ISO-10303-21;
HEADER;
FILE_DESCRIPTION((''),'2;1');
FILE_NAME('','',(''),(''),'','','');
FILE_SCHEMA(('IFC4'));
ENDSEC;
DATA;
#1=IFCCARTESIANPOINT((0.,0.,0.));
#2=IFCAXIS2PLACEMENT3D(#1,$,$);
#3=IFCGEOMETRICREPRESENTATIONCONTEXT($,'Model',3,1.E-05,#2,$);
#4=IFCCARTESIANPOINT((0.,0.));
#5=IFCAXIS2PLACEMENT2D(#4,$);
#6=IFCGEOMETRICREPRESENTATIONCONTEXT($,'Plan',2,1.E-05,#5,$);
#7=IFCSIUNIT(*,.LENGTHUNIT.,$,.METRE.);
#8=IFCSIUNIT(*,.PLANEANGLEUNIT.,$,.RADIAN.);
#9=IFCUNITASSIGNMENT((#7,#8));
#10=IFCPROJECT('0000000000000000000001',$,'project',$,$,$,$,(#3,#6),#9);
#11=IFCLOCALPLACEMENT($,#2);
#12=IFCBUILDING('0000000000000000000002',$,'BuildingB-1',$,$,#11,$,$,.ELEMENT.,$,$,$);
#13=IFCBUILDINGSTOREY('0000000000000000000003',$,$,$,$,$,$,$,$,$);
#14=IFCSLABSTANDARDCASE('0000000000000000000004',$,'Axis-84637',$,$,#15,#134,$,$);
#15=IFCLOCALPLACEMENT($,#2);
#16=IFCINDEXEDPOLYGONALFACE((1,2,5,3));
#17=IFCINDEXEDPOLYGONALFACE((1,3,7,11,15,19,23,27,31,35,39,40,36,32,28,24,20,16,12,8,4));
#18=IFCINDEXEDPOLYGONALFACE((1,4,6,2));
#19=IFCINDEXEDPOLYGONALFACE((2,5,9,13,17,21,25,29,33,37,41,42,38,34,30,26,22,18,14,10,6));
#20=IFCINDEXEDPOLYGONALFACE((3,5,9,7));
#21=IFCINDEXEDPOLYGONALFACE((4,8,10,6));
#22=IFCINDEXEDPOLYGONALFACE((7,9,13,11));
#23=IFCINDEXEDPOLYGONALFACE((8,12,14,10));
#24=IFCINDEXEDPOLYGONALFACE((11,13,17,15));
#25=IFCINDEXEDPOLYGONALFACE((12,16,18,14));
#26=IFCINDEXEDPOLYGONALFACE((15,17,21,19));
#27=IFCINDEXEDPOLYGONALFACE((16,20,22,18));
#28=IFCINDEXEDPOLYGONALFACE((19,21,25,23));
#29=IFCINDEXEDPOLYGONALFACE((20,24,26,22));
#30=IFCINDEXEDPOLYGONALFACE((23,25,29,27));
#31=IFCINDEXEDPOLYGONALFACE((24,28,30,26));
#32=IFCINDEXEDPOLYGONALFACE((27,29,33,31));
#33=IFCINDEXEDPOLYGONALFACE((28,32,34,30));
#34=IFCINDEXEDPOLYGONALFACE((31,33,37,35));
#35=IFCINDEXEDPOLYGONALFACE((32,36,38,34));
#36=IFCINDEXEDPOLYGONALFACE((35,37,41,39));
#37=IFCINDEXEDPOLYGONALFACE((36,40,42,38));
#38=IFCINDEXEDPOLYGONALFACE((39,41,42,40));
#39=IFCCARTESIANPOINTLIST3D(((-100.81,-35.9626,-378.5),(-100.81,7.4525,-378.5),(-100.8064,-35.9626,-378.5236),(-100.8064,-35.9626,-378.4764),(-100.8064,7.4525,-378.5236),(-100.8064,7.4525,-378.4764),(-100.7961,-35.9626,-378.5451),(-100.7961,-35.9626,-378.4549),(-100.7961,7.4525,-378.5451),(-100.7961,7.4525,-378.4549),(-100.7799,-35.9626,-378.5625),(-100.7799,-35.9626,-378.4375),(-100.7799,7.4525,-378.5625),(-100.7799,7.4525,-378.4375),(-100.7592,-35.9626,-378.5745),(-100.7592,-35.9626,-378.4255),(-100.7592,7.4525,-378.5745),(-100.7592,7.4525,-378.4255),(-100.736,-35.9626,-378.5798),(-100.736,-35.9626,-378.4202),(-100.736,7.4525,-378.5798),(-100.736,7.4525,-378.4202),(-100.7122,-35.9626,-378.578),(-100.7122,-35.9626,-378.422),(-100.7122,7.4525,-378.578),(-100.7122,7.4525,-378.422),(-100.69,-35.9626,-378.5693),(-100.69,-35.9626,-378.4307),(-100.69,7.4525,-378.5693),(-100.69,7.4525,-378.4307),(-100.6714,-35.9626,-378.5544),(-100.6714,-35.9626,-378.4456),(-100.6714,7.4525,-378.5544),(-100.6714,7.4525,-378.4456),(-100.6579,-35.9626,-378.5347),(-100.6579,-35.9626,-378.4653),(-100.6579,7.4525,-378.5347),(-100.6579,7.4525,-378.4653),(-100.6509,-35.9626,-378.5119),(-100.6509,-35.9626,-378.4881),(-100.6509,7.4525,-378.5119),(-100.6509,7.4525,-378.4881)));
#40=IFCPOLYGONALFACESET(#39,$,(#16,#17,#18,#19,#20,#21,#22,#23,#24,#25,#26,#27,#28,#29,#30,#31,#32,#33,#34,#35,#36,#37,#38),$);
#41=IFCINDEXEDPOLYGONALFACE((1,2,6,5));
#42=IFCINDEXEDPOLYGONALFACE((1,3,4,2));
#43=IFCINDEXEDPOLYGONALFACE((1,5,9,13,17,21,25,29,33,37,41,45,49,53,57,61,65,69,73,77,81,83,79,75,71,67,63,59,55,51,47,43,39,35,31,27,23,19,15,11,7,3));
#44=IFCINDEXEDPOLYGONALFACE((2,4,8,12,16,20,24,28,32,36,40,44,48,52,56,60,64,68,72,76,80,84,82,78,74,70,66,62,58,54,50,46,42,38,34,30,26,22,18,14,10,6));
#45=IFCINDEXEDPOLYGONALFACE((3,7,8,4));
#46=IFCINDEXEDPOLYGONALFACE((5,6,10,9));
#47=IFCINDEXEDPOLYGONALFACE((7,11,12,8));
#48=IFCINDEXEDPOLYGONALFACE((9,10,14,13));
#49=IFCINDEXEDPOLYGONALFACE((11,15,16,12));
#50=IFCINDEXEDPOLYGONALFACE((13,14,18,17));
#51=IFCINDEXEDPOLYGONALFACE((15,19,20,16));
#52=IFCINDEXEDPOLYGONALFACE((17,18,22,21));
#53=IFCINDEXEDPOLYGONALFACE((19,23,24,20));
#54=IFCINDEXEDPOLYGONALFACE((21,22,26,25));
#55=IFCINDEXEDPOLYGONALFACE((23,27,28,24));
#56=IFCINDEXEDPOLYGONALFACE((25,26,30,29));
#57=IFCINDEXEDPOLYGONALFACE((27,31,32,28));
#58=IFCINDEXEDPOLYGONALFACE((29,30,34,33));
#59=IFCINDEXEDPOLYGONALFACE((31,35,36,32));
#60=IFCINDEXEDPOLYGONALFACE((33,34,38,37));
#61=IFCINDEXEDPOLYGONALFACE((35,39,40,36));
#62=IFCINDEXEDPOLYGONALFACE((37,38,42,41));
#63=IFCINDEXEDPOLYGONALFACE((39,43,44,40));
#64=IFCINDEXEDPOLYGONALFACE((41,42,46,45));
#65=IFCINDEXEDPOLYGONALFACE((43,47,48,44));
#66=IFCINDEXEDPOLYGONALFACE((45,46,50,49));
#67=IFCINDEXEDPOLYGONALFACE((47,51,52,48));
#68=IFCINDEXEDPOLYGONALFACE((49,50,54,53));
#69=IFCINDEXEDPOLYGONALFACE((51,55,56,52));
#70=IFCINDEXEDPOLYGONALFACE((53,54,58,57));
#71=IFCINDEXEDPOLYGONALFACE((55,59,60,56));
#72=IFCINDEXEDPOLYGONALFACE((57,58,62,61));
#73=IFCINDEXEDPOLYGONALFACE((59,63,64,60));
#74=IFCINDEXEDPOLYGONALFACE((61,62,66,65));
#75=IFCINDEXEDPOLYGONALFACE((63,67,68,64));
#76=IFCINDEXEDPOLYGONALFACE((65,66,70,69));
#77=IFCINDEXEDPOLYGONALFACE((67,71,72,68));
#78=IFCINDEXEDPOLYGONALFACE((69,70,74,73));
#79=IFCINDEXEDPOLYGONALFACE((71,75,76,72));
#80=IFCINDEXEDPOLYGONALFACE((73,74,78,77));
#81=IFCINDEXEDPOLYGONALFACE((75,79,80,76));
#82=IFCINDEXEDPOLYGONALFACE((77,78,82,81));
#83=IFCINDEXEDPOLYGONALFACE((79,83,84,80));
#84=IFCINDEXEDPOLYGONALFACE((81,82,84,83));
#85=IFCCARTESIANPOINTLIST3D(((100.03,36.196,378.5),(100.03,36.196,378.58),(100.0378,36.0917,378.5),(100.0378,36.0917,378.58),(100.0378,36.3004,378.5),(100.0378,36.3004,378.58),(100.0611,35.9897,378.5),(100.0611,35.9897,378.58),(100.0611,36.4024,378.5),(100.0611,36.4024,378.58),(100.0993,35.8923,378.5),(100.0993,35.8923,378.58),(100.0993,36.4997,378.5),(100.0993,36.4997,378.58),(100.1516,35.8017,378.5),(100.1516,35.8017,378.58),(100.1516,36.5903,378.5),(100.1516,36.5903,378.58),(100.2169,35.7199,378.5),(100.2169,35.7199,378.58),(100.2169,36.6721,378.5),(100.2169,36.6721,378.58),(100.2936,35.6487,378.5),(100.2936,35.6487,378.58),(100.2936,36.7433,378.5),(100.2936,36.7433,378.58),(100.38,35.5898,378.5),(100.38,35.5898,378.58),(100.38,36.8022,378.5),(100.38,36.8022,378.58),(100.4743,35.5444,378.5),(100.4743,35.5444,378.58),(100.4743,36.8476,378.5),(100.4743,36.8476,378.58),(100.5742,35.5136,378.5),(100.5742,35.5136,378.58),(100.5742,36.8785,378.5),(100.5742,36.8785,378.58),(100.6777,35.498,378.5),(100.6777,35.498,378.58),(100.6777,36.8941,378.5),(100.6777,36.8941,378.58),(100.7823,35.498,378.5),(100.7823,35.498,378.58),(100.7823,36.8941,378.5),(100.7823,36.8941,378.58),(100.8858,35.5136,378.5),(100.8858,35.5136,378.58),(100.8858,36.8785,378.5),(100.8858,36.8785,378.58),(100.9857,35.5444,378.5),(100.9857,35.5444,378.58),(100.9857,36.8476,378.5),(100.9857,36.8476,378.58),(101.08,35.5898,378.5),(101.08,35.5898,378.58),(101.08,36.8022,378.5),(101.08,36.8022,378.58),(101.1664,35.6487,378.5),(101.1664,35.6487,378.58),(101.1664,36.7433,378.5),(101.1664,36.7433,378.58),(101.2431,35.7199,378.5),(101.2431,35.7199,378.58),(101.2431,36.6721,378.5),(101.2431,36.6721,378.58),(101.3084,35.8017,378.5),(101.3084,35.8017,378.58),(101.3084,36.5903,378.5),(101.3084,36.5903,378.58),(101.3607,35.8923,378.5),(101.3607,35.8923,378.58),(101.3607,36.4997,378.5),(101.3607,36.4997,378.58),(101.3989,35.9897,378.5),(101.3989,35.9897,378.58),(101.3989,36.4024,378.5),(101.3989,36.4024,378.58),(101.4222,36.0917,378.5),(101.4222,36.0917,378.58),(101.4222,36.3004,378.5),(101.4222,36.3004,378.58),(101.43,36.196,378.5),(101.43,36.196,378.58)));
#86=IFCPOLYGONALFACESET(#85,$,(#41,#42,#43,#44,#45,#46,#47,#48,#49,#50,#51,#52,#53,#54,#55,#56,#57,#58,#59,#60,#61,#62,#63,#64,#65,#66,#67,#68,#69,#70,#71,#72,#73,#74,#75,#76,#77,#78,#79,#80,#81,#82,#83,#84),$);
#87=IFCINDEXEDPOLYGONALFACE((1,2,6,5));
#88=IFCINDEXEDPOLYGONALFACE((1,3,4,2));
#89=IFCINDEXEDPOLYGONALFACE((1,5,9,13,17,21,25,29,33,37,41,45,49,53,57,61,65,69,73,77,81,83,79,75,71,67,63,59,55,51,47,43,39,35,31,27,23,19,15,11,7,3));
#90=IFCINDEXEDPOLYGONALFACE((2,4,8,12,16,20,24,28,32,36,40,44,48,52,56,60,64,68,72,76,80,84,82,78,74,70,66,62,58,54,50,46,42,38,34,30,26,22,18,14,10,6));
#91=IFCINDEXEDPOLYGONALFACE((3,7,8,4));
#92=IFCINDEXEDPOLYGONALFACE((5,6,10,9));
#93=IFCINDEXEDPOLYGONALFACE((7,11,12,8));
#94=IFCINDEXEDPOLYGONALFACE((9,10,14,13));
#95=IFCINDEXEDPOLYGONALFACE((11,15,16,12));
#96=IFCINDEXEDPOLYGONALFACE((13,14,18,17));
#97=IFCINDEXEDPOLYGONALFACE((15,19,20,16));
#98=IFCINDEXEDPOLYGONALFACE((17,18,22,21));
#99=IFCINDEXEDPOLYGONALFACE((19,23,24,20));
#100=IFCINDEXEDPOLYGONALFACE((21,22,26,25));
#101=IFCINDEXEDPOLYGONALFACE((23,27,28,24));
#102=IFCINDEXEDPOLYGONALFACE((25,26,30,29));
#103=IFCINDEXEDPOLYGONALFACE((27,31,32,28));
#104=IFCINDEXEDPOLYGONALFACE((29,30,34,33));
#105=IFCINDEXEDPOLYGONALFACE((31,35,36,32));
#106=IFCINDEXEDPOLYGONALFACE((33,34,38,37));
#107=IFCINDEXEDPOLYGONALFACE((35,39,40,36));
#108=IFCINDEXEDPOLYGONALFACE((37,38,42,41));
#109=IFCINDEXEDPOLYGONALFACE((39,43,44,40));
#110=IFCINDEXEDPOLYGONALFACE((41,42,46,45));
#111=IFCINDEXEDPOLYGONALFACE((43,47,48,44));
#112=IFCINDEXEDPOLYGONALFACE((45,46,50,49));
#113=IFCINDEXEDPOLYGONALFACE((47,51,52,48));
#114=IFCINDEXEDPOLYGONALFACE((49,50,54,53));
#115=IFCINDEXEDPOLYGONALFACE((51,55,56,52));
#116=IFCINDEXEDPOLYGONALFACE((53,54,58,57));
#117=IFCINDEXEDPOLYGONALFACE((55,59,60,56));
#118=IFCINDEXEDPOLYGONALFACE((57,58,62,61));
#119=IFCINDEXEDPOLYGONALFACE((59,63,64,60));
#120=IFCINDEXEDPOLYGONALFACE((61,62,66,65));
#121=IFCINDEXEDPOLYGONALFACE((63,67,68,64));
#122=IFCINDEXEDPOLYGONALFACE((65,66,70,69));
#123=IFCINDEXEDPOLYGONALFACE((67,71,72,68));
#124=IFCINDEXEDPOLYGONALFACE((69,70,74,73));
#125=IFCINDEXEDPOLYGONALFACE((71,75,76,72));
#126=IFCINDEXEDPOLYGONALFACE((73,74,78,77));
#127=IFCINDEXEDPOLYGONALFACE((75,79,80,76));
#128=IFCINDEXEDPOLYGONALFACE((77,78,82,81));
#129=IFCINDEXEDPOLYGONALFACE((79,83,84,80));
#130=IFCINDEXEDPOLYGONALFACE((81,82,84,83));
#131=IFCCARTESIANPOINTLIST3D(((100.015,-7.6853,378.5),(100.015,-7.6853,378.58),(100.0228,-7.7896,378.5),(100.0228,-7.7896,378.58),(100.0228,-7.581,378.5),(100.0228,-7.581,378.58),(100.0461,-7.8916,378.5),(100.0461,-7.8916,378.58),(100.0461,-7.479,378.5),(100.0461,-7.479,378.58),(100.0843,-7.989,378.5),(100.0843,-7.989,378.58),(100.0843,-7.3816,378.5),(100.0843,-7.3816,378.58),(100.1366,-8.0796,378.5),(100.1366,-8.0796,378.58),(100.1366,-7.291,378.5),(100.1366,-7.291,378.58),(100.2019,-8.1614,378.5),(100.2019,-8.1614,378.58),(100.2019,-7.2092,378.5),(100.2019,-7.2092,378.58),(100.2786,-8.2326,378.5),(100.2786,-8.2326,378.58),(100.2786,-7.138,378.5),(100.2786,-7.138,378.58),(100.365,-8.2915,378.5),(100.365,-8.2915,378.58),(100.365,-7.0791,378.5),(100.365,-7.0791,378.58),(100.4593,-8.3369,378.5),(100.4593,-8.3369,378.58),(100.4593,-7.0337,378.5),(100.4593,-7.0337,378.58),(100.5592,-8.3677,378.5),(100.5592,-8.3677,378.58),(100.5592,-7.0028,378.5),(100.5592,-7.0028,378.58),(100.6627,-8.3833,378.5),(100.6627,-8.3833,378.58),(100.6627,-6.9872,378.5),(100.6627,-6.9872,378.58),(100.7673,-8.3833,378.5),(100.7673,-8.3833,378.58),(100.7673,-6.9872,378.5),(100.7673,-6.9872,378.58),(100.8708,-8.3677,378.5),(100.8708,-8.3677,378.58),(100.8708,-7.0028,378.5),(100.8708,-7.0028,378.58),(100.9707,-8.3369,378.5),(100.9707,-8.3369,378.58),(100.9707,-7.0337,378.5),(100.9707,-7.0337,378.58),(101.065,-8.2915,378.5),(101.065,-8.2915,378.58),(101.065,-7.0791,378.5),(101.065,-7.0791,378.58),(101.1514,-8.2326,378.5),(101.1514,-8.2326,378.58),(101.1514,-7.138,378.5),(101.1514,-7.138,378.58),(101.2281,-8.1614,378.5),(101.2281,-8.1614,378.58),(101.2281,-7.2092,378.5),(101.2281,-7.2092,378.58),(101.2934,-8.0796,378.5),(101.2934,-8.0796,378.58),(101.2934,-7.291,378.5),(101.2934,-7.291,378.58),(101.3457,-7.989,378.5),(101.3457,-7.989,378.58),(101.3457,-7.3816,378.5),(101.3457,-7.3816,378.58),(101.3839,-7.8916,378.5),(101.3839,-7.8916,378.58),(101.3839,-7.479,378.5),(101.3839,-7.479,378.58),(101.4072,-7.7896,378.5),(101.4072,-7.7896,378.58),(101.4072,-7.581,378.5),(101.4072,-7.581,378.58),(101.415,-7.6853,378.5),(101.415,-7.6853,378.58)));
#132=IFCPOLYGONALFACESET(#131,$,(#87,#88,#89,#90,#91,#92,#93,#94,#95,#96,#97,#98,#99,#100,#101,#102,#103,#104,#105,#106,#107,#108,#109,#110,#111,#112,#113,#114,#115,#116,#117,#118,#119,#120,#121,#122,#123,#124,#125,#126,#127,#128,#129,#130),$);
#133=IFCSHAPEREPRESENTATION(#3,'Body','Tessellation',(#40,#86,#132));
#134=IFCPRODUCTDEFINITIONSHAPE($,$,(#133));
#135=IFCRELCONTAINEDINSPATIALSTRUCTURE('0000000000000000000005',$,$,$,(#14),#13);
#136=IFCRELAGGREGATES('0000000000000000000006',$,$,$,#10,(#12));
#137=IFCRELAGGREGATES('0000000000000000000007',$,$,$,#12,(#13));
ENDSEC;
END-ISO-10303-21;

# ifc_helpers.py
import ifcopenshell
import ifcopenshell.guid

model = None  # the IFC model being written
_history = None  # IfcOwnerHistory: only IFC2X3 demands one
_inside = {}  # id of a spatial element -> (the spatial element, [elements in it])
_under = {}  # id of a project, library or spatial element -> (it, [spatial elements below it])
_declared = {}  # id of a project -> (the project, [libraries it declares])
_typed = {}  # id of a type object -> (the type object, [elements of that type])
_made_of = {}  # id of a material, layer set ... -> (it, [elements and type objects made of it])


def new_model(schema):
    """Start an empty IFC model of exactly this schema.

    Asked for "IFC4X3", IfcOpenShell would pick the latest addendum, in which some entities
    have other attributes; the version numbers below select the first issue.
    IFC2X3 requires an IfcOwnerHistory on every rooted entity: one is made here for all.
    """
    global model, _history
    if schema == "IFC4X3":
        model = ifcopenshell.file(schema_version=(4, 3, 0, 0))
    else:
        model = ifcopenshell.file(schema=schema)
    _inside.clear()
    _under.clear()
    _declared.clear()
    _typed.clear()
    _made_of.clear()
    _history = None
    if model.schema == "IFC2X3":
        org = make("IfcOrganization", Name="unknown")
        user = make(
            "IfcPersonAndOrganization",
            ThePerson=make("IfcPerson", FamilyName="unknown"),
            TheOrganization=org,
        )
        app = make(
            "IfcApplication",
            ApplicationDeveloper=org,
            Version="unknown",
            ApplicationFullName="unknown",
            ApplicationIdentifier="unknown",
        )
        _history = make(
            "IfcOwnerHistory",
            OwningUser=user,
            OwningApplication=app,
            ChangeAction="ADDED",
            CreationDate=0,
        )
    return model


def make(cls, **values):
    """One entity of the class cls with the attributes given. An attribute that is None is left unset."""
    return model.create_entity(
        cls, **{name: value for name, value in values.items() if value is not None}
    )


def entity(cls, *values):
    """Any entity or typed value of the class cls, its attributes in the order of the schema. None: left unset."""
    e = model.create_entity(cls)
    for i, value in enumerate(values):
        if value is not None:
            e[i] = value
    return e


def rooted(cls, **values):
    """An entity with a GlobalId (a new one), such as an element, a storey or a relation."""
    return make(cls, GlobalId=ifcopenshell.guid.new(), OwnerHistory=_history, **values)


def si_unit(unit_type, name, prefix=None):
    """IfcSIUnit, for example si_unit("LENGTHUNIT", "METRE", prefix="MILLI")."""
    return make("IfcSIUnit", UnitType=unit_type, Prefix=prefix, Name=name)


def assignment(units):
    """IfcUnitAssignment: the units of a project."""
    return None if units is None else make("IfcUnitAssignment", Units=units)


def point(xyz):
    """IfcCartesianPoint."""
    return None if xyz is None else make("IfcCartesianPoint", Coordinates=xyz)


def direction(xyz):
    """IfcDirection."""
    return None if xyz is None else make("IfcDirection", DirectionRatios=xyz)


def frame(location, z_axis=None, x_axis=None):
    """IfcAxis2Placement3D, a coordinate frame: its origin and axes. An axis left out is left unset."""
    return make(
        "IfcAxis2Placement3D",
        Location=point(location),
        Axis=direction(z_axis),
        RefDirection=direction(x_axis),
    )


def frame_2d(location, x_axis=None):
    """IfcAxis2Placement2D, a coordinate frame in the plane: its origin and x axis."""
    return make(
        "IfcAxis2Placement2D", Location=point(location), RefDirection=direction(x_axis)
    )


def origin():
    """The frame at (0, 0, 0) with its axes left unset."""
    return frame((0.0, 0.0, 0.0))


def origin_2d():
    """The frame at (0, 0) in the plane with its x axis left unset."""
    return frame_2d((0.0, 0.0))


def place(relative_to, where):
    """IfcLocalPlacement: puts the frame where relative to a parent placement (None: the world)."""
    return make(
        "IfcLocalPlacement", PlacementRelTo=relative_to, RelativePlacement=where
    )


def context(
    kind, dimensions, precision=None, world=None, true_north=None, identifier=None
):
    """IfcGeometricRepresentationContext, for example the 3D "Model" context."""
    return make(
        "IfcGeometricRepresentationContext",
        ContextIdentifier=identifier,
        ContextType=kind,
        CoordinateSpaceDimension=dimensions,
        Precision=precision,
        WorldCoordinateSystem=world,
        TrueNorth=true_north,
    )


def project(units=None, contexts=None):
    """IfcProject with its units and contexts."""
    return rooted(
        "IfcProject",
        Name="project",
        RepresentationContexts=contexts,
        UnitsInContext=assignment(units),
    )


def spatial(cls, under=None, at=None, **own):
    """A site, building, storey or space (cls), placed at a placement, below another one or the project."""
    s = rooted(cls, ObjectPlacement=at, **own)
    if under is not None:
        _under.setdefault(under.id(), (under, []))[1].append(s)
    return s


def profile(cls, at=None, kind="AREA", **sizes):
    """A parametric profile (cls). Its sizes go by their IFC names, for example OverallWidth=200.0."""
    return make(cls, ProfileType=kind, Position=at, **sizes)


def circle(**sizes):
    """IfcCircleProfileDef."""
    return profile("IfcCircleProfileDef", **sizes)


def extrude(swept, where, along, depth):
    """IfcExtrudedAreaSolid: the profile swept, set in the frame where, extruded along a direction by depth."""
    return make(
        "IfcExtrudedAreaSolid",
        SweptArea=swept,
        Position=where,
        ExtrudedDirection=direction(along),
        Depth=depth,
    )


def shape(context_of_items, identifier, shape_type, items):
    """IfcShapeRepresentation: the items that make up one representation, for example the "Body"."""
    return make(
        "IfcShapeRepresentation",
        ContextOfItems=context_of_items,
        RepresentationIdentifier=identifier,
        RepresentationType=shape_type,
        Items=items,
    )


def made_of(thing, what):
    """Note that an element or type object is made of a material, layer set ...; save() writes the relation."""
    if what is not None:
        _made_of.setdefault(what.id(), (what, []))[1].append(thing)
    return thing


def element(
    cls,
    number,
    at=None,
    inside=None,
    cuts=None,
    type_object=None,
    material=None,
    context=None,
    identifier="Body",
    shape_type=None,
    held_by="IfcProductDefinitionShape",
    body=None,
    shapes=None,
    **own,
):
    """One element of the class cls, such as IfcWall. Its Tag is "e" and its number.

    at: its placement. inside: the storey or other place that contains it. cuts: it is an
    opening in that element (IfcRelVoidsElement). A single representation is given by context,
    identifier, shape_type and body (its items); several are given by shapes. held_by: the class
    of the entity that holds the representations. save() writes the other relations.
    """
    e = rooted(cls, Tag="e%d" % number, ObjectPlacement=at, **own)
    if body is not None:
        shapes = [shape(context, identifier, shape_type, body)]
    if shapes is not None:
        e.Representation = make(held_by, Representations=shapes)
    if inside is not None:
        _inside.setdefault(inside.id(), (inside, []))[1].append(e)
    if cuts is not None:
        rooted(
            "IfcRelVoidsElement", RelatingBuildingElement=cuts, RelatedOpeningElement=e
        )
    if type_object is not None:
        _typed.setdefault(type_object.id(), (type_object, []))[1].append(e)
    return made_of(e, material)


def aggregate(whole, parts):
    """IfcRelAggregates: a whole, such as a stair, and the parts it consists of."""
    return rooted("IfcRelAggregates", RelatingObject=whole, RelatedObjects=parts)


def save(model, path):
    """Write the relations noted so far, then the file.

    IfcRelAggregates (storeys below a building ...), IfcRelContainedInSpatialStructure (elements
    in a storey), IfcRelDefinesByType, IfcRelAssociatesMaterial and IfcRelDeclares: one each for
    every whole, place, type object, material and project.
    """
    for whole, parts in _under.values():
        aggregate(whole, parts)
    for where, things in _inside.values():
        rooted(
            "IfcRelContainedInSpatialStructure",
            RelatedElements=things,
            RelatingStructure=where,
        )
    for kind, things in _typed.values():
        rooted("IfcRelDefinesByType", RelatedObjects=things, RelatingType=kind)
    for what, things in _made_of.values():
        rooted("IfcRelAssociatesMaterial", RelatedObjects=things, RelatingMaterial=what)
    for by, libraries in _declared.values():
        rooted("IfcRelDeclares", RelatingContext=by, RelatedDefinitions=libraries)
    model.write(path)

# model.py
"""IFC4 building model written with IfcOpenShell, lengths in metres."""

from ifc_helpers import new_model, entity, si_unit, frame, origin, origin_2d, place, context, project, spatial, circle, extrude, element, save


model = new_model("IFC4")

# Units and contexts
model_context = context("Model", 3, precision=1e-05, world=origin())
plan_context = context("Plan", 2, precision=1e-05, world=origin_2d())
ifc_project = project(units=[si_unit("LENGTHUNIT", "METRE"), si_unit("PLANEANGLEUNIT", "RADIAN")], contexts=[model_context, plan_context])

# Building, storey
building_placement = place(None, origin())
building = spatial("IfcBuilding", under=ifc_project, at=building_placement, Name="BuildingB-1", CompositionType="ELEMENT")
storey = spatial("IfcBuildingStorey", under=building)

# Slab
element("IfcSlabStandardCase", 1, inside=storey, Name="Axis-84637", context=model_context, shape_type="AdvancedSweptSolid", body=[
    entity("IfcSurfaceCurveSweptAreaSolid", entity("IfcCircleProfileDef", "AREA", None, None, 0.08), None, entity("IfcPolyline", [entity("IfcCartesianPoint", [100.73, 35.9626, 378.5]), entity("IfcCartesianPoint", [100.73, -7.4525, 378.5])]), None, None, entity("IfcPlane", entity("IfcAxis2Placement3D", entity("IfcCartesianPoint", [100.73, 35.9626, 378.5]), entity("IfcDirection", [0.0, 0.0, 1.0]), entity("IfcDirection", [1.0, 0.0, 0.0])))),
    extrude(circle(Radius=0.7), frame((100.73, 36.196, 378.5)), (0.0, 0.0, 1.0), 0.08),
    extrude(circle(Radius=0.7), frame((100.715, -7.6853, 378.5)), (0.0, 0.0, 1.0), 0.08),
])

save(model, "model.ifc")
